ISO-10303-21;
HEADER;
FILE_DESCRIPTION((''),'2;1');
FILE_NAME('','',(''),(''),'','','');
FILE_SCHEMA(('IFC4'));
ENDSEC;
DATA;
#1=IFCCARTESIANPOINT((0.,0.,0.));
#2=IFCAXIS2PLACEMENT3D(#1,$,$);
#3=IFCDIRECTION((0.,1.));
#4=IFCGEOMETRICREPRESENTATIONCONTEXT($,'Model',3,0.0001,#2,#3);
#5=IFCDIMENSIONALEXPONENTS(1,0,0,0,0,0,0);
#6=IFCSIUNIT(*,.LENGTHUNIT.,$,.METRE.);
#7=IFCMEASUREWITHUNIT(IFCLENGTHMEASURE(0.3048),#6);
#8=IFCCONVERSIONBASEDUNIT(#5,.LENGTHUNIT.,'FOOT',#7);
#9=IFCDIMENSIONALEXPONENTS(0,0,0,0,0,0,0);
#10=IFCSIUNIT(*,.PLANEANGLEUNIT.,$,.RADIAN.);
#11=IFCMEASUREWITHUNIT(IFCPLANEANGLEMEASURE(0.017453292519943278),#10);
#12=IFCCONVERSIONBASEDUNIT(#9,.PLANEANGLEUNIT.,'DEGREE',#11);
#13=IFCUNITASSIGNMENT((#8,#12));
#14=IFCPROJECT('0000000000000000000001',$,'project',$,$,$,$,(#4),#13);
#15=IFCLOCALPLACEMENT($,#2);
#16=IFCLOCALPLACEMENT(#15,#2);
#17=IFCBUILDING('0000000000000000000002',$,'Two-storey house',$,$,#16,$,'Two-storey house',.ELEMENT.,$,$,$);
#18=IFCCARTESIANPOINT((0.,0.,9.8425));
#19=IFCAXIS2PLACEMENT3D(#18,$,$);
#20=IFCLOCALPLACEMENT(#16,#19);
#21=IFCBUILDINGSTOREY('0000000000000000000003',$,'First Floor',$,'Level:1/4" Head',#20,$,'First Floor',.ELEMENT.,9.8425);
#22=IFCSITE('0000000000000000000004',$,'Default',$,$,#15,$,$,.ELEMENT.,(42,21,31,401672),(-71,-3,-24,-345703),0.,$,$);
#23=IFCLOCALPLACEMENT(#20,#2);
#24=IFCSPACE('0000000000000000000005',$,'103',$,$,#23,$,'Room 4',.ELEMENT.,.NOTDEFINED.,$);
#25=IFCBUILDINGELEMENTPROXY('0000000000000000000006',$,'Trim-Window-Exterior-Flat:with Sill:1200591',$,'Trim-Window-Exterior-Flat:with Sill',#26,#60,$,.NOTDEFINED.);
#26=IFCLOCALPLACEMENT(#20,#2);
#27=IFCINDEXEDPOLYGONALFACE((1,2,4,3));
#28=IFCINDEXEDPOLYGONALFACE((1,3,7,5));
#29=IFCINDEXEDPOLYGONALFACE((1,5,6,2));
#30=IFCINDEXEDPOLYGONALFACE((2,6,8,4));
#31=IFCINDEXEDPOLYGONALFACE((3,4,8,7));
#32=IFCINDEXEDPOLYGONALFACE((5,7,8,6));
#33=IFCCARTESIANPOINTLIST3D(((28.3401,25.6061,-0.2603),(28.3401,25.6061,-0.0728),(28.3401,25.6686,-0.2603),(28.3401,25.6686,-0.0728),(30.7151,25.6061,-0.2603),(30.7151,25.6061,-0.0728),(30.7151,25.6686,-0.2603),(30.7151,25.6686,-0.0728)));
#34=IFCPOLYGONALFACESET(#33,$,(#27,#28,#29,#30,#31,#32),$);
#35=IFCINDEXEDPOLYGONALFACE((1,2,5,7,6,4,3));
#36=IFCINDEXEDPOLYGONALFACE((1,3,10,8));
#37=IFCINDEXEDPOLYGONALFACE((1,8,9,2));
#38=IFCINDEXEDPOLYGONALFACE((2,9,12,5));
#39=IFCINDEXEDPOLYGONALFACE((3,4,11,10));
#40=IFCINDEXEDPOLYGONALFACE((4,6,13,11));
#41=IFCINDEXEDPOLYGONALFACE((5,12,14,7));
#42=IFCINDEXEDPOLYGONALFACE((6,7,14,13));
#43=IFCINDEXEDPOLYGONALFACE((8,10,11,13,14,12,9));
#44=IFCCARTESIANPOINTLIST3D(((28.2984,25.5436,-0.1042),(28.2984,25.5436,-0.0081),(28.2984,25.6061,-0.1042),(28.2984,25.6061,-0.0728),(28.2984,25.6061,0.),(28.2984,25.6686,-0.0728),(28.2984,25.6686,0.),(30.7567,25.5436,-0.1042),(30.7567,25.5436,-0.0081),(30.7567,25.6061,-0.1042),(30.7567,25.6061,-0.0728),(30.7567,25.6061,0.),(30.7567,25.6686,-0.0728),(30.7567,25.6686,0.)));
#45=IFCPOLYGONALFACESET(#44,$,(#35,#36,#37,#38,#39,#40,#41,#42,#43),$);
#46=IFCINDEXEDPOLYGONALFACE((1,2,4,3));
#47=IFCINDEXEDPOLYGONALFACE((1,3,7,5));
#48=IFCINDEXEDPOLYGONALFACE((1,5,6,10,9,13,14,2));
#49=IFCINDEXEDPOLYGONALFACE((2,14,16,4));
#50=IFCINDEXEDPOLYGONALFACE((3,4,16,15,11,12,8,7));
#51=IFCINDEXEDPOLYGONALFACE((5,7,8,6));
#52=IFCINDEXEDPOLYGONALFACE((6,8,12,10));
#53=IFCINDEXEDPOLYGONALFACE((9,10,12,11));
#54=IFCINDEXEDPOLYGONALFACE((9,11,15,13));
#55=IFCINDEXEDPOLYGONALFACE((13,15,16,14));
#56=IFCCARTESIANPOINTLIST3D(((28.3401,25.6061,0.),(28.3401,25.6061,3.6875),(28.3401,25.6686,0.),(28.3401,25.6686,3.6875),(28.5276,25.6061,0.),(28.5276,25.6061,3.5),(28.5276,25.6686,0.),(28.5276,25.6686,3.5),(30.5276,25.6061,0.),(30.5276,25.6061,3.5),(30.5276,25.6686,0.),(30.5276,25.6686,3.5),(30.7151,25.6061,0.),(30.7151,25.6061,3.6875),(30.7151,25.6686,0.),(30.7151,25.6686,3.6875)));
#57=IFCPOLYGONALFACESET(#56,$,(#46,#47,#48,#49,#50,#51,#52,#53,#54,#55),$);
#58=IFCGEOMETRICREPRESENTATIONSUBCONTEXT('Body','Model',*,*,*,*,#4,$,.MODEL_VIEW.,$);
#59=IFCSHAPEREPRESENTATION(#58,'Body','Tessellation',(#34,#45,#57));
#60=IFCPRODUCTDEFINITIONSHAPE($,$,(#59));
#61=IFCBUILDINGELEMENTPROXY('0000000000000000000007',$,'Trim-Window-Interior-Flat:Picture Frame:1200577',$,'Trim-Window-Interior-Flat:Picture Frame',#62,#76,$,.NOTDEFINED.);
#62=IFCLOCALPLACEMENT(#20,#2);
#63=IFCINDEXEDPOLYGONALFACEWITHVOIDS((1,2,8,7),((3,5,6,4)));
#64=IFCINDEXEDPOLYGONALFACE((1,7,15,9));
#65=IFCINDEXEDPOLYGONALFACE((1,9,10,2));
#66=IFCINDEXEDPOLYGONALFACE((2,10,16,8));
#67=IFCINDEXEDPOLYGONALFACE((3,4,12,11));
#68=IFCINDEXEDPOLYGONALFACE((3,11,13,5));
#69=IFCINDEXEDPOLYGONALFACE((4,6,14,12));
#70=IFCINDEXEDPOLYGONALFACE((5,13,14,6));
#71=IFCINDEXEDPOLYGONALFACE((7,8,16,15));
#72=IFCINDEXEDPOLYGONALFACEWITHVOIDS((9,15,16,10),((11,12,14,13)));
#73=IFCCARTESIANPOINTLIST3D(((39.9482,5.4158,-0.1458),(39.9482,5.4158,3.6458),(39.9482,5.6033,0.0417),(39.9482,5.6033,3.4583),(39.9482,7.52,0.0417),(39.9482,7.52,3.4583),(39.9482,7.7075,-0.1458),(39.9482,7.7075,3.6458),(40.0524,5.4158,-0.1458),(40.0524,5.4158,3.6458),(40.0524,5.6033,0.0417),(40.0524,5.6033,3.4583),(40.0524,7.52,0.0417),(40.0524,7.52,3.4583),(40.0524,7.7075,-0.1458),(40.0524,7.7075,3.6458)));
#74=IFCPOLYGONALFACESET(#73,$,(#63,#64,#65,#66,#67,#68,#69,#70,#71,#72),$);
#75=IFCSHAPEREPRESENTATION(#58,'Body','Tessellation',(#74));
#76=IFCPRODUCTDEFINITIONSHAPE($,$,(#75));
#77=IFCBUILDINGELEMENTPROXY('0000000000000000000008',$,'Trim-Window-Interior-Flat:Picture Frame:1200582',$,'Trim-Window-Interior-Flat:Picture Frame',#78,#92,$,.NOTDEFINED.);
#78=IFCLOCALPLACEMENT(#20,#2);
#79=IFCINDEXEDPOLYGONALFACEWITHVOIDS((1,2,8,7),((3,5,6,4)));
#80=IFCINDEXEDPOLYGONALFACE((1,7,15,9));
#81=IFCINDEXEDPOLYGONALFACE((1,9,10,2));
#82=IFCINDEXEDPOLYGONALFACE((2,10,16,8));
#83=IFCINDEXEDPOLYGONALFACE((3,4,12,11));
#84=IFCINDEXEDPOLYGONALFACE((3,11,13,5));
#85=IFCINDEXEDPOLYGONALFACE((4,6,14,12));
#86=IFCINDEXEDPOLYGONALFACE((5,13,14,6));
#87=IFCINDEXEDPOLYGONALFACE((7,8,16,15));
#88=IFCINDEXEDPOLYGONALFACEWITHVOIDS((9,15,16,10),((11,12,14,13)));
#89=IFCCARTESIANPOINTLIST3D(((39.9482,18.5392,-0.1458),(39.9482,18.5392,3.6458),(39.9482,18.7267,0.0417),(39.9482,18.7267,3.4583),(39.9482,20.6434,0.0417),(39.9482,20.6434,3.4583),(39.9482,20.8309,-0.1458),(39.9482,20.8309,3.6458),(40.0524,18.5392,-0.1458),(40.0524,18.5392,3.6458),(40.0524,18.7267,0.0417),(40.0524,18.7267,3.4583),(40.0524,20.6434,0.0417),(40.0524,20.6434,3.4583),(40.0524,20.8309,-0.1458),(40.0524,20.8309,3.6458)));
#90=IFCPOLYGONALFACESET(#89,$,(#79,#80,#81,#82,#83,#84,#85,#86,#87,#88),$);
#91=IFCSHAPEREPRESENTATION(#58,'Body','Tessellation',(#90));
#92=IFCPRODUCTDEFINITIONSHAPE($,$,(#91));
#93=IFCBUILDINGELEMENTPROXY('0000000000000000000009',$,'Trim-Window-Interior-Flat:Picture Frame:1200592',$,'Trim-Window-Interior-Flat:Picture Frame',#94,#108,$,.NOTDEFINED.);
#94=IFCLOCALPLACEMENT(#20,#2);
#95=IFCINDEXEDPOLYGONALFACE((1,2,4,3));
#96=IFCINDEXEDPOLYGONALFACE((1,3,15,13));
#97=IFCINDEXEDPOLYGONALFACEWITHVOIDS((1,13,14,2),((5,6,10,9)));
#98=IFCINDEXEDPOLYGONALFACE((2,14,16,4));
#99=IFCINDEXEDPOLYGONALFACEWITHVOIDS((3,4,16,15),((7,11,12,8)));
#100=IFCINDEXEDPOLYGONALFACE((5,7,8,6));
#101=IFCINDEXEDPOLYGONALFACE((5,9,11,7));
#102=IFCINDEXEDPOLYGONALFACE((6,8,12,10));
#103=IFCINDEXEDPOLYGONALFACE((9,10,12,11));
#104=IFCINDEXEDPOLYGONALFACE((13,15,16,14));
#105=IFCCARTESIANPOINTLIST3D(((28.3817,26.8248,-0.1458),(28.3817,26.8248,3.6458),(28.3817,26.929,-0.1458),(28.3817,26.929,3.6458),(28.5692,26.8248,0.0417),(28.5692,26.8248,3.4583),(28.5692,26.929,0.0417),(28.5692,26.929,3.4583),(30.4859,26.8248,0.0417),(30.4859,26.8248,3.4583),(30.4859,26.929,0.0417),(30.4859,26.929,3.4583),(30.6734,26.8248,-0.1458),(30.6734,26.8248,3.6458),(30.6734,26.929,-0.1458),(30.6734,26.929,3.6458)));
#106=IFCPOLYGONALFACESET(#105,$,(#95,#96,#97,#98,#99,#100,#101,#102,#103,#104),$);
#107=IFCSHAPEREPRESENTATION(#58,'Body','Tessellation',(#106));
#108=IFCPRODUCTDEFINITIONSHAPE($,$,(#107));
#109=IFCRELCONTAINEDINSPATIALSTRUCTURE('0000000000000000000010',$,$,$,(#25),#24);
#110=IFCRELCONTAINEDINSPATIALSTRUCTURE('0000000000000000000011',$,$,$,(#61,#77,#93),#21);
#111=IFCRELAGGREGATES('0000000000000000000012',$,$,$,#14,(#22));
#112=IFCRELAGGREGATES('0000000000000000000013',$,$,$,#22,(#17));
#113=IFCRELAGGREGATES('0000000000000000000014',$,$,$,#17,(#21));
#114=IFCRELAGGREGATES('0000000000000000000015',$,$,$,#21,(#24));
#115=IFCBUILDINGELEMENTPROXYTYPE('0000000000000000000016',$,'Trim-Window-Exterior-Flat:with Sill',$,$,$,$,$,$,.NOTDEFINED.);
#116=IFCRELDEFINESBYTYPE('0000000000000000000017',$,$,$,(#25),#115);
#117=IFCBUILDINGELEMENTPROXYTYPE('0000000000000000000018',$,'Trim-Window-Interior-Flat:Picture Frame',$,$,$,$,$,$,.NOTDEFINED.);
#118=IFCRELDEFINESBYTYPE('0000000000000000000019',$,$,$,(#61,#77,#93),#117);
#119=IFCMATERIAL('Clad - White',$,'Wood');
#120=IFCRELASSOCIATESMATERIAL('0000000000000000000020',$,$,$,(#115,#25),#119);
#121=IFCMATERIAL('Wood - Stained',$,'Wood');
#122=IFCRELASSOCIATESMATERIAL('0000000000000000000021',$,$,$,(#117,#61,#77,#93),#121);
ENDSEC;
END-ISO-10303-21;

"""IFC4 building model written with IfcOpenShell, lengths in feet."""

from ifc_helpers import new_model, entity, si_unit, converted_unit, direction, frame, origin, place, context, subcontext, project, spatial, indexed_curve, outline, extrude, source, transform, mapped, material, type_object, type_shapes, element, save


model = new_model("IFC4")

# Units and contexts
model_context = context("Model", 3, precision=0.0001, world=origin(), true_north=direction((0.0, 1.0)))
body_context = subcontext(model_context, "Body", "Model", "MODEL_VIEW")
ifc_project = project(units=[converted_unit("LENGTHUNIT", "FOOT", entity("IfcLengthMeasure", 0.3048), si_unit("LENGTHUNIT", "METRE"), dimensions=[1, 0, 0, 0, 0, 0, 0]), converted_unit("PLANEANGLEUNIT", "DEGREE", entity("IfcPlaneAngleMeasure", 0.017453292519943278), si_unit("PLANEANGLEUNIT", "RADIAN"), dimensions=[0, 0, 0, 0, 0, 0, 0])], contexts=[model_context])

# Site, building, storey
site_placement = place(None, origin())
site = spatial("IfcSite", under=ifc_project, at=site_placement, Name="Default", CompositionType="ELEMENT", RefLatitude=(42, 21, 31, 401672), RefLongitude=(-71, -3, -24, -345703), RefElevation=0.0)
building_placement = place(site_placement, origin())
building = spatial("IfcBuilding", under=site, at=building_placement, Name="Two-storey house", LongName="Two-storey house", CompositionType="ELEMENT")
storey_placement = place(building_placement, frame((0.0, 0.0, 9.8425)))
storey = spatial("IfcBuildingStorey", under=building, at=storey_placement, Name="First Floor", ObjectType="Level:1/4\" Head", LongName="First Floor", CompositionType="ELEMENT", Elevation=9.8425)

# Shared definitions
ifc_material_1 = material(Name="Wood - Stained", Category="Wood")

# Shared definitions
ifc_material_2 = material(Name="Clad - White", Category="Wood")

# Shared definitions
space_placement = place(storey_placement, origin())
space = spatial("IfcSpace", under=storey, at=space_placement, Name="103", LongName="Room 4", CompositionType="ELEMENT", PredefinedType="NOTDEFINED")

# Building element proxies
building_element_proxy_type_1 = type_object("IfcBuildingElementProxyType", Name="Trim-Window-Exterior-Flat:with Sill", PredefinedType="NOTDEFINED", material=ifc_material_2)
shared_shape_1 = source(origin(), body_context, "Body", "SweptSolid", [
    extrude(outline(indexed_curve([(-1.1875, -0.0938), (1.1875, -0.0938), (1.1875, 0.0938), (-1.1875, 0.0938), (-1.1875, -0.0938)], self_intersect=False)), frame((0.0, -3.6665, 0.0), z_axis=(0.0, 0.0, 1.0), x_axis=(-1.0, 0.0, 0.0)), (0.0, 0.0, 1.0), 0.0625),
    extrude(outline(indexed_curve([(-0.0625, -0.0525), (0.0, -0.0525), (0.0, -0.0211), (0.0625, -0.0211), (0.0625, 0.0517), (0.0, 0.0517), (-0.0625, 0.0436), (-0.0625, -0.0525)], self_intersect=False)), frame((-1.2292, -3.5517, 0.0625), z_axis=(1.0, 0.0, 0.0), x_axis=(0.0, 0.0, -1.0)), (0.0, 0.0, 1.0), 2.4583),
    extrude(outline(indexed_curve([(-1.8906, -1.1875), (1.7969, -1.1875), (1.7969, -1.0), (-1.7031, -1.0), (-1.7031, 1.0), (1.7969, 1.0), (1.7969, 1.1875), (-1.8906, 1.1875), (-1.8906, -1.1875)], self_intersect=False)), frame((0.0, -1.7031, 0.0), z_axis=(0.0, 0.0, 1.0), x_axis=(0.0, -1.0, 0.0)), (0.0, 0.0, 1.0), 0.0625),
])
type_shapes(building_element_proxy_type_1, [shared_shape_1])
for number, where, z_axis, x_axis, name in (
    (1, (29.5276, 25.6686, 3.5), (0.0, -1.0, 0.0), (1.0, 0.0, 0.0), "Trim-Window-Exterior-Flat:with Sill:1200591"),
):
    element("IfcBuildingElementProxy", number, at=place(space_placement, frame(where, z_axis=z_axis, x_axis=x_axis)), inside=space, type_object=building_element_proxy_type_1, material=ifc_material_2, Name=name, ObjectType="Trim-Window-Exterior-Flat:with Sill", PredefinedType="NOTDEFINED", context=body_context, shape_type="MappedRepresentation", body=[
        mapped(shared_shape_1, transform((0.0, 0.0, 0.0), scale=1.0)),
    ])
building_element_proxy_type_2 = type_object("IfcBuildingElementProxyType", Name="Trim-Window-Interior-Flat:Picture Frame", PredefinedType="NOTDEFINED", material=ifc_material_1)
shared_shape_2 = source(origin(), body_context, "Body", "SweptSolid", [
    extrude(outline(indexed_curve([(-1.1458, -1.8958), (1.1458, -1.8958), (1.1458, 1.8958), (-1.1458, 1.8958), (-1.1458, -1.8958)], self_intersect=False), holes=[indexed_curve([(-0.9583, -1.7083), (-0.9583, 1.7083), (0.9583, 1.7083), (0.9583, -1.7083), (-0.9583, -1.7083)], self_intersect=False)]), frame((0.0, -1.75, 0.0), z_axis=(0.0, 0.0, 1.0), x_axis=(-1.0, 0.0, 0.0)), (0.0, 0.0, 1.0), 0.1042),
])
type_shapes(building_element_proxy_type_2, [shared_shape_2])
for number, where, z_axis, x_axis, name in (
    (2, (39.9482, 6.5617, 3.5), (1.0, 0.0, 0.0), (0.0, 1.0, 0.0), "Trim-Window-Interior-Flat:Picture Frame:1200577"),
    (3, (39.9482, 19.685, 3.5), (1.0, 0.0, 0.0), (0.0, 1.0, 0.0), "Trim-Window-Interior-Flat:Picture Frame:1200582"),
    (4, (29.5276, 26.8248, 3.5), (0.0, 1.0, 0.0), (-1.0, 0.0, 0.0), "Trim-Window-Interior-Flat:Picture Frame:1200592"),
):
    element("IfcBuildingElementProxy", number, at=place(storey_placement, frame(where, z_axis=z_axis, x_axis=x_axis)), inside=storey, type_object=building_element_proxy_type_2, material=ifc_material_1, Name=name, ObjectType="Trim-Window-Interior-Flat:Picture Frame", PredefinedType="NOTDEFINED", context=body_context, shape_type="MappedRepresentation", body=[
        mapped(shared_shape_2, transform((0.0, 0.0, 0.0), scale=1.0)),
    ])

save(model, "model.ifc")
